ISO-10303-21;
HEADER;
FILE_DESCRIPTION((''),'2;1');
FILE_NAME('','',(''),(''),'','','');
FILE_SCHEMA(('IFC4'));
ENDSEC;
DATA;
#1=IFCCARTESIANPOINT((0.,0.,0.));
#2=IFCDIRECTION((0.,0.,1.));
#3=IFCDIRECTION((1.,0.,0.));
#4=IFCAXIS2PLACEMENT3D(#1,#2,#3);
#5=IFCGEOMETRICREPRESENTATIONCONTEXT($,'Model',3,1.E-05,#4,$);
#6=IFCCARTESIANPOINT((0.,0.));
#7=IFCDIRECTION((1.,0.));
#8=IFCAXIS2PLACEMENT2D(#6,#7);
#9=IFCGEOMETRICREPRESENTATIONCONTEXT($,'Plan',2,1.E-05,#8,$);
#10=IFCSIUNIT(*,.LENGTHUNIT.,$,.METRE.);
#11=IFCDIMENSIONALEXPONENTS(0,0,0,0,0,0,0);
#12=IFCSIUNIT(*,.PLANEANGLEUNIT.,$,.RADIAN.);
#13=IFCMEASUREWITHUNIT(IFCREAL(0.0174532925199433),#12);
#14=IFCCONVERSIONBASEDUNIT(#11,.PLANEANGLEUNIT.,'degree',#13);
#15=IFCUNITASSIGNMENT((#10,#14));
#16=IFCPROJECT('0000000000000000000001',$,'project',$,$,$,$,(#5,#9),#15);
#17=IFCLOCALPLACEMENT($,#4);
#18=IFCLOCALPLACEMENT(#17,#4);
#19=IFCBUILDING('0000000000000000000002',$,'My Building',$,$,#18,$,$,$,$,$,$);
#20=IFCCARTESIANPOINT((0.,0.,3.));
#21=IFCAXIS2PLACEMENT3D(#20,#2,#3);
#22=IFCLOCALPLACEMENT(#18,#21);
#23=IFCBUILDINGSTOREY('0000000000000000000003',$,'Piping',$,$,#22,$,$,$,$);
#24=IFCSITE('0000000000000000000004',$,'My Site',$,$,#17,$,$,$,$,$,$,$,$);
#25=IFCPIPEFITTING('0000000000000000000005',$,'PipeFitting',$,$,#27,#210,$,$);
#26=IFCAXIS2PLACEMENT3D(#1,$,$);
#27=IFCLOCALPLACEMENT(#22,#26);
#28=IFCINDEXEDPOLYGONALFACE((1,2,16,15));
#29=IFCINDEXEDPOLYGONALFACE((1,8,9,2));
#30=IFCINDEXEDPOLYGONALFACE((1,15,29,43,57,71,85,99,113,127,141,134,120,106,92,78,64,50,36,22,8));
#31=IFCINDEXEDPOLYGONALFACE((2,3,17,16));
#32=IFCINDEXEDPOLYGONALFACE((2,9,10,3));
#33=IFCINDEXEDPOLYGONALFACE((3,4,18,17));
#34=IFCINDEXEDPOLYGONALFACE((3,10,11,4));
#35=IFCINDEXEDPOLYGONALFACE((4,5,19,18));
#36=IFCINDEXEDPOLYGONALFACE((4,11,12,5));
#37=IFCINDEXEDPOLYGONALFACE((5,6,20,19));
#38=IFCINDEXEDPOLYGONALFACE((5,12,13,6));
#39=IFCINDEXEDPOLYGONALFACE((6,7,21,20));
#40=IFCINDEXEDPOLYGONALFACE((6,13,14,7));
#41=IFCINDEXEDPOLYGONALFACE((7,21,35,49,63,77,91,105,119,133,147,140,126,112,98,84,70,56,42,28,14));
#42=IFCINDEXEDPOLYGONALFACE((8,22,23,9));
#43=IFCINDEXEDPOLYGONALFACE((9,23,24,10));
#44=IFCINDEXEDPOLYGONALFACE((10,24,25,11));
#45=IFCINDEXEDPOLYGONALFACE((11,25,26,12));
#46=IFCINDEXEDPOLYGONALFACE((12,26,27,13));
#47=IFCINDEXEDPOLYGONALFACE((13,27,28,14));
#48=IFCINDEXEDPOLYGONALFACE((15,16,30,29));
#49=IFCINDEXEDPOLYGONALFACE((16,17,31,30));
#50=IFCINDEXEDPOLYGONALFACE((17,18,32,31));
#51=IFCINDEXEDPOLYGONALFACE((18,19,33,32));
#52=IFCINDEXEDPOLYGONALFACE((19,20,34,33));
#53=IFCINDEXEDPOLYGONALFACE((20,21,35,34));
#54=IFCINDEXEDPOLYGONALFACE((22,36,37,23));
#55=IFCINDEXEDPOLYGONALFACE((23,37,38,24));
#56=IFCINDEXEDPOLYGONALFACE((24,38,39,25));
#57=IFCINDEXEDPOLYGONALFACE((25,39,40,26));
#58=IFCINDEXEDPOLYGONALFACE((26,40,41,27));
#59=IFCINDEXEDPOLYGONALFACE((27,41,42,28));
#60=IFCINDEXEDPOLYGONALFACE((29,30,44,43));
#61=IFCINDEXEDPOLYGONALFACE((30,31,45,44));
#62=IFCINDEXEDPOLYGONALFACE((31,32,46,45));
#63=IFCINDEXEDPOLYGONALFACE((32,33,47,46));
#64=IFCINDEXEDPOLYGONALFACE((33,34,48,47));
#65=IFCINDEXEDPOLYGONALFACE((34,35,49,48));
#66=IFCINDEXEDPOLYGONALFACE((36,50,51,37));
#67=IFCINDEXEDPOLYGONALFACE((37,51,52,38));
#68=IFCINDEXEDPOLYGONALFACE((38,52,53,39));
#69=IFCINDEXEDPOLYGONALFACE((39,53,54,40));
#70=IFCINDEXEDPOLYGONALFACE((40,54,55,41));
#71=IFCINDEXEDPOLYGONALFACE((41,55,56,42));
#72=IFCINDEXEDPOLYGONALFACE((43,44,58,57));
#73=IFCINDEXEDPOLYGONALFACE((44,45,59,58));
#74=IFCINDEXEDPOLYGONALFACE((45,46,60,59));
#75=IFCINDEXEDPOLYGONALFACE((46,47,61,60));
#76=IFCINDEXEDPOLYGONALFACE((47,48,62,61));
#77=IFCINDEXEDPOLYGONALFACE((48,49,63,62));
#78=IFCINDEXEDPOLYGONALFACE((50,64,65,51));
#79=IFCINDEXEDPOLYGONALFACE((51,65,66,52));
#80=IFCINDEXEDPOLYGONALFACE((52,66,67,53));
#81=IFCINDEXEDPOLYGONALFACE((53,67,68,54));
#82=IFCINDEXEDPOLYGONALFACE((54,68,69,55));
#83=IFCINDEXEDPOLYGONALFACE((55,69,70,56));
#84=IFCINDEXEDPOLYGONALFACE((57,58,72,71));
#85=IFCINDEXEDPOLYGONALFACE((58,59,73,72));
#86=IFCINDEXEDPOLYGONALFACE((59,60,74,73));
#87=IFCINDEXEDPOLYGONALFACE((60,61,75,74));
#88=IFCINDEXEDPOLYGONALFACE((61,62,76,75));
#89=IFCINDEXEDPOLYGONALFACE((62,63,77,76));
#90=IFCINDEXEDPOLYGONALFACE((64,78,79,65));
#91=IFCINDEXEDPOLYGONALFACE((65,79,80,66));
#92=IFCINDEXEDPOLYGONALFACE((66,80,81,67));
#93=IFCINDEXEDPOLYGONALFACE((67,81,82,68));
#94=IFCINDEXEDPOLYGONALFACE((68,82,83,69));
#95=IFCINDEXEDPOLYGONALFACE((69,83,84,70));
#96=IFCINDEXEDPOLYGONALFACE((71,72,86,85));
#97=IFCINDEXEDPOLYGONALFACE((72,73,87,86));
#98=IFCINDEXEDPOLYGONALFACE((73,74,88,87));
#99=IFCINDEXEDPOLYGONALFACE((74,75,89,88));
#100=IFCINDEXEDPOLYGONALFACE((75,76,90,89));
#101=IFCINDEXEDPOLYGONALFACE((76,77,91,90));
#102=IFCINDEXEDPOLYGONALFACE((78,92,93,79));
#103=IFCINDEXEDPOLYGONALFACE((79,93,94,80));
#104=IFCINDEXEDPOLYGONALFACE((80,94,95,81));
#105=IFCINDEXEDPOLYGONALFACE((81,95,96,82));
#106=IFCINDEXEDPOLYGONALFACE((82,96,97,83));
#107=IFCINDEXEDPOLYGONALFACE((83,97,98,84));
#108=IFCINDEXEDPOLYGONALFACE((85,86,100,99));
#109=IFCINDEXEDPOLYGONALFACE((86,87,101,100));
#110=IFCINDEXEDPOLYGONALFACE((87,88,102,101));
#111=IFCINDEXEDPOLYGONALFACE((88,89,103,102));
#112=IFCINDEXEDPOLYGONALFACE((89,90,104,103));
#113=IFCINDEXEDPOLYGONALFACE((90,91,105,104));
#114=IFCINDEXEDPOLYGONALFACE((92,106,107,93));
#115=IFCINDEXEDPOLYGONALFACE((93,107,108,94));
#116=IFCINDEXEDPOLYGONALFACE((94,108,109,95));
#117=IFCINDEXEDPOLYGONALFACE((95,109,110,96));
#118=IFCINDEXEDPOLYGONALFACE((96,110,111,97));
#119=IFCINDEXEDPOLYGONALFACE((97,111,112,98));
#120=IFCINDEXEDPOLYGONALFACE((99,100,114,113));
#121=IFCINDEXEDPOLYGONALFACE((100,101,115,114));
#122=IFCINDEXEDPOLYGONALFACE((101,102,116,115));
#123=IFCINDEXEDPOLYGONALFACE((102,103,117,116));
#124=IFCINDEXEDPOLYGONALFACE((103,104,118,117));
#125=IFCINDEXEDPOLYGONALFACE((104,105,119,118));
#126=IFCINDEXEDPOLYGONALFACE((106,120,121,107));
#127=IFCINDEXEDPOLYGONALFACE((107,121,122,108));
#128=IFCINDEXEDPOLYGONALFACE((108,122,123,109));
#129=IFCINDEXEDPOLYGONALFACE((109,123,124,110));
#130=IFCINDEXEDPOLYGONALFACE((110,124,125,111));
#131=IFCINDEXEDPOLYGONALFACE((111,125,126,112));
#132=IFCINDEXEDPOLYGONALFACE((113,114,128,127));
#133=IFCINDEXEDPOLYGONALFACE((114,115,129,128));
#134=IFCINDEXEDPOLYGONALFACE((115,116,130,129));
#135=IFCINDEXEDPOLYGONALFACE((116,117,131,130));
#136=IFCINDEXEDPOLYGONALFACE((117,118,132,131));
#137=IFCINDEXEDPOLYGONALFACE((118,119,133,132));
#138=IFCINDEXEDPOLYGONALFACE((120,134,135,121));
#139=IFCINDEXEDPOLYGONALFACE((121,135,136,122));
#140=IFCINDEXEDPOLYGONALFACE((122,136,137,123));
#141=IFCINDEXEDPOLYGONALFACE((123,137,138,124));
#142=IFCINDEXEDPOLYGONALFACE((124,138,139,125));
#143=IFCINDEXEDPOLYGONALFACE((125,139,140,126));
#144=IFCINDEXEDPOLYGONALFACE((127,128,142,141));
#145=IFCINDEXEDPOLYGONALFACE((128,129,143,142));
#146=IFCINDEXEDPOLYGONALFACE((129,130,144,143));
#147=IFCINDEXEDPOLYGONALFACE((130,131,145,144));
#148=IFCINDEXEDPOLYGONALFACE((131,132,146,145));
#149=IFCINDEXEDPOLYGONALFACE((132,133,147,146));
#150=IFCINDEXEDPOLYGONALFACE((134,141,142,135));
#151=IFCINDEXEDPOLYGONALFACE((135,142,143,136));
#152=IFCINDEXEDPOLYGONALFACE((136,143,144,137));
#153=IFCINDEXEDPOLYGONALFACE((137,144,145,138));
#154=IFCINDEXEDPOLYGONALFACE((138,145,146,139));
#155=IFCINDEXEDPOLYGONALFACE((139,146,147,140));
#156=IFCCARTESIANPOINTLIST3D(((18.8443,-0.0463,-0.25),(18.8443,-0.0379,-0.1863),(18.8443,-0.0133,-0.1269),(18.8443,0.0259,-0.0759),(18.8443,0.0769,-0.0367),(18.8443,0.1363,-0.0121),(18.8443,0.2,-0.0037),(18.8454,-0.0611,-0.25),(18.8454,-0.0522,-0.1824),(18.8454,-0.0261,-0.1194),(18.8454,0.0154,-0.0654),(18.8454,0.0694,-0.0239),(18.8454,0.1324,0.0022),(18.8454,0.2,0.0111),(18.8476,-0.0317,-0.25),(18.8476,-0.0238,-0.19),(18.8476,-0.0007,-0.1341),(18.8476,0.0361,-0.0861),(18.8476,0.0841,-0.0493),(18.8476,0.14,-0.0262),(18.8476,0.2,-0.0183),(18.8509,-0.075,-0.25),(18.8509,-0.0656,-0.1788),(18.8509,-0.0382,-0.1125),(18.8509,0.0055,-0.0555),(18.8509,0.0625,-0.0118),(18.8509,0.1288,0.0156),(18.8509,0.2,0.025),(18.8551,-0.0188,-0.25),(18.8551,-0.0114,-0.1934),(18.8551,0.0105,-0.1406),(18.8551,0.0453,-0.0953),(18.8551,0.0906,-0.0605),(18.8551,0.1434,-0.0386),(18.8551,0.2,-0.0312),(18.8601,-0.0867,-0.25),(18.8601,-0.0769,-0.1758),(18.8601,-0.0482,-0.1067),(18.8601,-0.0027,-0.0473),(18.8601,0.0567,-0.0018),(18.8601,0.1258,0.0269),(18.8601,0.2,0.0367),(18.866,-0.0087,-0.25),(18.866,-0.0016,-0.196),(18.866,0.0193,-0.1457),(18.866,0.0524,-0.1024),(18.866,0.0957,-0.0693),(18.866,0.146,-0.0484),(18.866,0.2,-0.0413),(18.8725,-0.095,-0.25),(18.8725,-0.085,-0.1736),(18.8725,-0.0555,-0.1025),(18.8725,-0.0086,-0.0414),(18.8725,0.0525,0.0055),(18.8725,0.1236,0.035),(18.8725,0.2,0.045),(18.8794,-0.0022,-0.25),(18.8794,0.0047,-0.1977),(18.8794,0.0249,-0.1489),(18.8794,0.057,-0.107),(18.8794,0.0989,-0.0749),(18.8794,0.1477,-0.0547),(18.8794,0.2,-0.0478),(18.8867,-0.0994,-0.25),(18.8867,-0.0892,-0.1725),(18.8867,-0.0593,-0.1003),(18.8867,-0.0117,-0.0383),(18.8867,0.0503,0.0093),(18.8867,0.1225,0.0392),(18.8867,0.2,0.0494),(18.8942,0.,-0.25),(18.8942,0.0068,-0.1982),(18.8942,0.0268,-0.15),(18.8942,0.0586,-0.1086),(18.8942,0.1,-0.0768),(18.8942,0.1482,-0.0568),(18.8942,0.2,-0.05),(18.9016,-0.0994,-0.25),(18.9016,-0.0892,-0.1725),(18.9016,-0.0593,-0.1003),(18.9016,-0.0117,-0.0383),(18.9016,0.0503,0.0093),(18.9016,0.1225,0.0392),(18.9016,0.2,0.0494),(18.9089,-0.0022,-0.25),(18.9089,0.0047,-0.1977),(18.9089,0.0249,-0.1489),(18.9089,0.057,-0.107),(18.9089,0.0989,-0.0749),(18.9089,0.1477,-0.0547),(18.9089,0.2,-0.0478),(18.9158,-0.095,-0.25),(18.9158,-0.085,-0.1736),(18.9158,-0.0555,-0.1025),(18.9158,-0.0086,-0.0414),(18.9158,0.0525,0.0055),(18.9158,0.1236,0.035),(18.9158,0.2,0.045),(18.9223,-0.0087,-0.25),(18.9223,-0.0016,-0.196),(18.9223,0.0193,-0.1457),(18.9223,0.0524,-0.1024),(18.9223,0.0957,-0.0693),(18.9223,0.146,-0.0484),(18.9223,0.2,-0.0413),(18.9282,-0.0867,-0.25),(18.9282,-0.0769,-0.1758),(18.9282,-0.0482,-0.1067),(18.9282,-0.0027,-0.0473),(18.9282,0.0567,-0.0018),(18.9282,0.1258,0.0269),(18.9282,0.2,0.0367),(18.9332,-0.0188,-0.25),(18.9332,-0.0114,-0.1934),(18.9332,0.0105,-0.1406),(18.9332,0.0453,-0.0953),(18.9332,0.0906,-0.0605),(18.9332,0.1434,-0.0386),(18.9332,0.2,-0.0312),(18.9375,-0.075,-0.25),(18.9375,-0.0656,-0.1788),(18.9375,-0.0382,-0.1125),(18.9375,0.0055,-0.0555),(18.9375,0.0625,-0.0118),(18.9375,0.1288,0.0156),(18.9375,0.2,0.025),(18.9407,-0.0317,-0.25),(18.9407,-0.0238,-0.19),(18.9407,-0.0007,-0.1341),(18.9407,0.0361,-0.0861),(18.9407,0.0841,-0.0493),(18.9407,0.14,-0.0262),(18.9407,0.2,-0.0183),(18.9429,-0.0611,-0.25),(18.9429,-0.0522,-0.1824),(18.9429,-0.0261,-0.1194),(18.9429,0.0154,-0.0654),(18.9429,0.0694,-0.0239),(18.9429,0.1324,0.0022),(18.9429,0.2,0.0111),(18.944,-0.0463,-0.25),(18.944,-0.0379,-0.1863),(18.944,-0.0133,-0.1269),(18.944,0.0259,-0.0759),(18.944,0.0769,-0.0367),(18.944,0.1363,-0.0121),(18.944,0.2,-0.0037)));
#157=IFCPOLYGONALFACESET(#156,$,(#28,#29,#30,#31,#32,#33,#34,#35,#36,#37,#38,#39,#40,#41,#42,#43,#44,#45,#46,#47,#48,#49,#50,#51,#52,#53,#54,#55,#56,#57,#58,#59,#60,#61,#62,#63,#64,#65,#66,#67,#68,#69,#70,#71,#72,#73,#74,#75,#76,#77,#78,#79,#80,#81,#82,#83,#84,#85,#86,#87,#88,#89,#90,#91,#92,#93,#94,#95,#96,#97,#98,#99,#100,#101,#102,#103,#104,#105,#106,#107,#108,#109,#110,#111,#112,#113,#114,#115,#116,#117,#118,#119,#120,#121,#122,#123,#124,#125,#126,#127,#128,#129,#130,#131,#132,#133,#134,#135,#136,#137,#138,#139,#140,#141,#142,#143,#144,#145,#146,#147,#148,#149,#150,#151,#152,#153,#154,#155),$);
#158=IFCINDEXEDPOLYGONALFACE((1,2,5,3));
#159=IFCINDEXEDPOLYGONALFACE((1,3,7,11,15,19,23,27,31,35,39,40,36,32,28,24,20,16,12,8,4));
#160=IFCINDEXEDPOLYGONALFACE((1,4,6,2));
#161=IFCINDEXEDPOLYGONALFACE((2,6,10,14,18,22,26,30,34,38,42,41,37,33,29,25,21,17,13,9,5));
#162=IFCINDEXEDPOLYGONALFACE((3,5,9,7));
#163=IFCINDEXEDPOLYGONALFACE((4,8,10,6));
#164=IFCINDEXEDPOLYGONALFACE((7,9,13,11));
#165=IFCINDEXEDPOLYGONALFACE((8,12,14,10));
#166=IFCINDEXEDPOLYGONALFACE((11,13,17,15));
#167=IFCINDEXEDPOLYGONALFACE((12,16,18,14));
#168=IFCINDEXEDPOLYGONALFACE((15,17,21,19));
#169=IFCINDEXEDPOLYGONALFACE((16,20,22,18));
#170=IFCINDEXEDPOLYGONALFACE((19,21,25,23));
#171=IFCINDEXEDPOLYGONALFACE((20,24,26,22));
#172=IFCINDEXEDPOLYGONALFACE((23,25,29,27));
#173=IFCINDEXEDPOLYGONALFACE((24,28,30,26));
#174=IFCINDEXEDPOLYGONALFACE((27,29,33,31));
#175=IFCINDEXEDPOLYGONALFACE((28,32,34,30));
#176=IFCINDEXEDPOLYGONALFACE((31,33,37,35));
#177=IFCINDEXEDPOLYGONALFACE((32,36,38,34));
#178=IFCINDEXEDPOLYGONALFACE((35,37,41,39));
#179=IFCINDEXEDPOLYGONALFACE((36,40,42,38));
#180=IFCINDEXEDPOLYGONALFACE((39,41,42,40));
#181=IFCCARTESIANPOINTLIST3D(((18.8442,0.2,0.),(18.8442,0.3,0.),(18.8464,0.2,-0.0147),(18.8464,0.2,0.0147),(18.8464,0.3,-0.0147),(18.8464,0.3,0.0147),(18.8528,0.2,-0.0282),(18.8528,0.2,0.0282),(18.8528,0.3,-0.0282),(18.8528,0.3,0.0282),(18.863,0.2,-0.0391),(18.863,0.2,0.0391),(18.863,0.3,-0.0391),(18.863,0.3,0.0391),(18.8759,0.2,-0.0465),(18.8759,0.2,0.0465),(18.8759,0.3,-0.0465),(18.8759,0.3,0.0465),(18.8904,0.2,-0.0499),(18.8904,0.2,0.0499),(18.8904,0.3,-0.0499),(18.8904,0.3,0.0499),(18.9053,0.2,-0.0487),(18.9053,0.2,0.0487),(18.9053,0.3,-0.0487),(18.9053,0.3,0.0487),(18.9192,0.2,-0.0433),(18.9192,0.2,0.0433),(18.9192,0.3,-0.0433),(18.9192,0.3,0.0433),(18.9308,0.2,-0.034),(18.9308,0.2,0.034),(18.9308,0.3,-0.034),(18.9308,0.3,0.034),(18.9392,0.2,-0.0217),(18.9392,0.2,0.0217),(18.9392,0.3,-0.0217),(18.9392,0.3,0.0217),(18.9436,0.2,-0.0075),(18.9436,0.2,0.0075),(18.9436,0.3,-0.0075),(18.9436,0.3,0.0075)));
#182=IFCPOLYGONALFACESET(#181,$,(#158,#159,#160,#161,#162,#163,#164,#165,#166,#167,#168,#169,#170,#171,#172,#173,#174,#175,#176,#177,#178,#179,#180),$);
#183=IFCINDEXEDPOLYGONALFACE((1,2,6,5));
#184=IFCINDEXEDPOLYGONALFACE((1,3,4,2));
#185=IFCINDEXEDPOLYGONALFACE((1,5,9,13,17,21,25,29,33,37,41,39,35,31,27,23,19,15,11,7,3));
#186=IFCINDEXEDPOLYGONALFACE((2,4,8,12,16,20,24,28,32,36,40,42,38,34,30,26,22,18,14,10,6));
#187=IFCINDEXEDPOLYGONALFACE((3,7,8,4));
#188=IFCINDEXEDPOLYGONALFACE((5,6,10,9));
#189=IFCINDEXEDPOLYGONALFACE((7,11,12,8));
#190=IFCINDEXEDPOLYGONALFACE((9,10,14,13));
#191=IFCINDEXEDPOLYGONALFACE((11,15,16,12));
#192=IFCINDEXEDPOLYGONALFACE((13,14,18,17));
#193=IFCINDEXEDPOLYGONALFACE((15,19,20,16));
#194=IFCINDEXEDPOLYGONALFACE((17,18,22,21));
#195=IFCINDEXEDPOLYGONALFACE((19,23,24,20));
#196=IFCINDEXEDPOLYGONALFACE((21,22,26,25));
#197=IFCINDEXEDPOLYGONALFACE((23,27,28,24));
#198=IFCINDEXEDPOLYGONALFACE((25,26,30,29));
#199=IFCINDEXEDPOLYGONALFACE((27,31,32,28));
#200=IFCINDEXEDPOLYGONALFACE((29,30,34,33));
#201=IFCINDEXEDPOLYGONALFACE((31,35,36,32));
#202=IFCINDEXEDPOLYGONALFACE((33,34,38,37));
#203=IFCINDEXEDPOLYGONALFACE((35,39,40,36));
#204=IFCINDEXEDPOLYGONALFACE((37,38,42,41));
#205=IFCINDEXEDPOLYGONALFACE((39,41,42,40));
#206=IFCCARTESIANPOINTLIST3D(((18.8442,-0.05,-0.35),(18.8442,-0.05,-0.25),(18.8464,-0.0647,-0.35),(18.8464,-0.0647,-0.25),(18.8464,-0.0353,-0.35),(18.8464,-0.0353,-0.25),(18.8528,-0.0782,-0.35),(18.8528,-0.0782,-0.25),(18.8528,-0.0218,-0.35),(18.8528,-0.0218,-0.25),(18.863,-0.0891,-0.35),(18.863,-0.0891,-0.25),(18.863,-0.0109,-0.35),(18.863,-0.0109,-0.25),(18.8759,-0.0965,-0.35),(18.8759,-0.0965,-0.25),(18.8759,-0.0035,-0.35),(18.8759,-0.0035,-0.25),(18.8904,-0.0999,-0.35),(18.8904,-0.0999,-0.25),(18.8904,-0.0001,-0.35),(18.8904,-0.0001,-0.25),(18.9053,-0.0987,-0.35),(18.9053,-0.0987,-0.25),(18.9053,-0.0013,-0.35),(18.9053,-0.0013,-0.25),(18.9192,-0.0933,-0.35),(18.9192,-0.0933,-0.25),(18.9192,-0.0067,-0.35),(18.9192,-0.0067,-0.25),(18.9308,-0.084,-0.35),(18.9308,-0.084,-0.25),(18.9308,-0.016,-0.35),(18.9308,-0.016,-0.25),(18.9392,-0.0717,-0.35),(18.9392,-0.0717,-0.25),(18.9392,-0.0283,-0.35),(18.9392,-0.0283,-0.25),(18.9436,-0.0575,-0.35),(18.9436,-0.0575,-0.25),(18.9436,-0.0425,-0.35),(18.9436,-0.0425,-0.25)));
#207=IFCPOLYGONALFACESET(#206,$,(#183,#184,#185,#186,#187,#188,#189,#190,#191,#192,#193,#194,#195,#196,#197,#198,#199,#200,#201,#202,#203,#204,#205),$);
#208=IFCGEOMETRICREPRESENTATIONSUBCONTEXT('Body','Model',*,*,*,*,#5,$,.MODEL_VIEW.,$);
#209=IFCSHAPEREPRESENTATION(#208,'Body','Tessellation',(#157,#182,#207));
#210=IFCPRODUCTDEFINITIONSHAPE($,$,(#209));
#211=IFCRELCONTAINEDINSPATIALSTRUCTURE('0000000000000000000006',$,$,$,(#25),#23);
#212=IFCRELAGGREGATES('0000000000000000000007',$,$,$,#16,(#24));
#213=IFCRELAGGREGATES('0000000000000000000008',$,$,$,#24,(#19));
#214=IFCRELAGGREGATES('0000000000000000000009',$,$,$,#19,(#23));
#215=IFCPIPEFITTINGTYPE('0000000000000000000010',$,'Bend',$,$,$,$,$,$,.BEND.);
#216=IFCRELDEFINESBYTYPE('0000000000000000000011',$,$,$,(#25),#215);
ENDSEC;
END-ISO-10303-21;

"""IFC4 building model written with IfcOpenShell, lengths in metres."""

from ifc_helpers import new_model, entity, si_unit, converted_unit, frame, origin_with_axes, origin_2d_with_axis, place, context, subcontext, project, spatial, circle, extrude, source, transform, mapped, type_object, type_shapes, element, save


model = new_model("IFC4")

# Units and contexts
model_context = context("Model", 3, precision=1e-05, world=origin_with_axes())
plan_context = context("Plan", 2, precision=1e-05, world=origin_2d_with_axis())
body_context = subcontext(model_context, "Body", "Model", "MODEL_VIEW")
ifc_project = project(units=[si_unit("LENGTHUNIT", "METRE"), converted_unit("PLANEANGLEUNIT", "degree", entity("IfcReal", 0.0174532925199433), si_unit("PLANEANGLEUNIT", "RADIAN"), dimensions=[0, 0, 0, 0, 0, 0, 0])], contexts=[model_context, plan_context])

# Site, building, storey
site_placement = place(None, origin_with_axes())
site = spatial("IfcSite", under=ifc_project, at=site_placement, Name="My Site")
building_placement = place(site_placement, origin_with_axes())
building = spatial("IfcBuilding", under=site, at=building_placement, Name="My Building")
storey_placement = place(building_placement, frame((0.0, 0.0, 3.0), z_axis=(0.0, 0.0, 1.0), x_axis=(1.0, 0.0, 0.0)))
storey = spatial("IfcBuildingStorey", under=building, at=storey_placement, Name="Piping")

# Shared definitions
pipe_fitting_type = type_object("IfcPipeFittingType", Name="Bend", PredefinedType="BEND")
shared_shape = source(origin_with_axes(), body_context, "Body", "SolidModel", [
    entity("IfcSweptDiskSolid", entity("IfcIndexedPolyCurve", entity("IfcCartesianPointList3D", [[0.0, 0.0, -0.1], [0.0, -0.0732, -0.2768], [0.0, -0.25, -0.35]]), [entity("IfcArcIndex", [1, 2, 3])]), 0.05),
    extrude(circle(Radius=0.05), origin_with_axes(), (0.0, 0.0, -1.0), 0.1),
    extrude(circle(Radius=0.05), frame((0.0, -0.25, -0.35), z_axis=(0.0, -1.0, 0.0), x_axis=(1.0, 0.0, 0.0)), (0.0, 0.0, 1.0), 0.1),
])
type_shapes(pipe_fitting_type, [shared_shape])

# Pipe fitting
for number, where, z_axis, x_axis, name in (
    (1, (18.8942, 0.3, 0.0), (0.0, 1.0, 0.0), (-1.0, 0.0, 0.0), "PipeFitting"),
):
    element("IfcPipeFitting", number, at=place(storey_placement, frame(where, z_axis=z_axis, x_axis=x_axis)), inside=storey, type_object=pipe_fitting_type, Name=name, context=body_context, shape_type="MappedRepresentation", body=[
        mapped(shared_shape, transform((0.0, 0.0, 0.0), x_axis=(1.0, 0.0, 0.0), y_axis=(0.0, 1.0, 0.0), z_axis=(0.0, 0.0, 1.0), scale=1.0)),
    ])

save(model, "model.ifc")
